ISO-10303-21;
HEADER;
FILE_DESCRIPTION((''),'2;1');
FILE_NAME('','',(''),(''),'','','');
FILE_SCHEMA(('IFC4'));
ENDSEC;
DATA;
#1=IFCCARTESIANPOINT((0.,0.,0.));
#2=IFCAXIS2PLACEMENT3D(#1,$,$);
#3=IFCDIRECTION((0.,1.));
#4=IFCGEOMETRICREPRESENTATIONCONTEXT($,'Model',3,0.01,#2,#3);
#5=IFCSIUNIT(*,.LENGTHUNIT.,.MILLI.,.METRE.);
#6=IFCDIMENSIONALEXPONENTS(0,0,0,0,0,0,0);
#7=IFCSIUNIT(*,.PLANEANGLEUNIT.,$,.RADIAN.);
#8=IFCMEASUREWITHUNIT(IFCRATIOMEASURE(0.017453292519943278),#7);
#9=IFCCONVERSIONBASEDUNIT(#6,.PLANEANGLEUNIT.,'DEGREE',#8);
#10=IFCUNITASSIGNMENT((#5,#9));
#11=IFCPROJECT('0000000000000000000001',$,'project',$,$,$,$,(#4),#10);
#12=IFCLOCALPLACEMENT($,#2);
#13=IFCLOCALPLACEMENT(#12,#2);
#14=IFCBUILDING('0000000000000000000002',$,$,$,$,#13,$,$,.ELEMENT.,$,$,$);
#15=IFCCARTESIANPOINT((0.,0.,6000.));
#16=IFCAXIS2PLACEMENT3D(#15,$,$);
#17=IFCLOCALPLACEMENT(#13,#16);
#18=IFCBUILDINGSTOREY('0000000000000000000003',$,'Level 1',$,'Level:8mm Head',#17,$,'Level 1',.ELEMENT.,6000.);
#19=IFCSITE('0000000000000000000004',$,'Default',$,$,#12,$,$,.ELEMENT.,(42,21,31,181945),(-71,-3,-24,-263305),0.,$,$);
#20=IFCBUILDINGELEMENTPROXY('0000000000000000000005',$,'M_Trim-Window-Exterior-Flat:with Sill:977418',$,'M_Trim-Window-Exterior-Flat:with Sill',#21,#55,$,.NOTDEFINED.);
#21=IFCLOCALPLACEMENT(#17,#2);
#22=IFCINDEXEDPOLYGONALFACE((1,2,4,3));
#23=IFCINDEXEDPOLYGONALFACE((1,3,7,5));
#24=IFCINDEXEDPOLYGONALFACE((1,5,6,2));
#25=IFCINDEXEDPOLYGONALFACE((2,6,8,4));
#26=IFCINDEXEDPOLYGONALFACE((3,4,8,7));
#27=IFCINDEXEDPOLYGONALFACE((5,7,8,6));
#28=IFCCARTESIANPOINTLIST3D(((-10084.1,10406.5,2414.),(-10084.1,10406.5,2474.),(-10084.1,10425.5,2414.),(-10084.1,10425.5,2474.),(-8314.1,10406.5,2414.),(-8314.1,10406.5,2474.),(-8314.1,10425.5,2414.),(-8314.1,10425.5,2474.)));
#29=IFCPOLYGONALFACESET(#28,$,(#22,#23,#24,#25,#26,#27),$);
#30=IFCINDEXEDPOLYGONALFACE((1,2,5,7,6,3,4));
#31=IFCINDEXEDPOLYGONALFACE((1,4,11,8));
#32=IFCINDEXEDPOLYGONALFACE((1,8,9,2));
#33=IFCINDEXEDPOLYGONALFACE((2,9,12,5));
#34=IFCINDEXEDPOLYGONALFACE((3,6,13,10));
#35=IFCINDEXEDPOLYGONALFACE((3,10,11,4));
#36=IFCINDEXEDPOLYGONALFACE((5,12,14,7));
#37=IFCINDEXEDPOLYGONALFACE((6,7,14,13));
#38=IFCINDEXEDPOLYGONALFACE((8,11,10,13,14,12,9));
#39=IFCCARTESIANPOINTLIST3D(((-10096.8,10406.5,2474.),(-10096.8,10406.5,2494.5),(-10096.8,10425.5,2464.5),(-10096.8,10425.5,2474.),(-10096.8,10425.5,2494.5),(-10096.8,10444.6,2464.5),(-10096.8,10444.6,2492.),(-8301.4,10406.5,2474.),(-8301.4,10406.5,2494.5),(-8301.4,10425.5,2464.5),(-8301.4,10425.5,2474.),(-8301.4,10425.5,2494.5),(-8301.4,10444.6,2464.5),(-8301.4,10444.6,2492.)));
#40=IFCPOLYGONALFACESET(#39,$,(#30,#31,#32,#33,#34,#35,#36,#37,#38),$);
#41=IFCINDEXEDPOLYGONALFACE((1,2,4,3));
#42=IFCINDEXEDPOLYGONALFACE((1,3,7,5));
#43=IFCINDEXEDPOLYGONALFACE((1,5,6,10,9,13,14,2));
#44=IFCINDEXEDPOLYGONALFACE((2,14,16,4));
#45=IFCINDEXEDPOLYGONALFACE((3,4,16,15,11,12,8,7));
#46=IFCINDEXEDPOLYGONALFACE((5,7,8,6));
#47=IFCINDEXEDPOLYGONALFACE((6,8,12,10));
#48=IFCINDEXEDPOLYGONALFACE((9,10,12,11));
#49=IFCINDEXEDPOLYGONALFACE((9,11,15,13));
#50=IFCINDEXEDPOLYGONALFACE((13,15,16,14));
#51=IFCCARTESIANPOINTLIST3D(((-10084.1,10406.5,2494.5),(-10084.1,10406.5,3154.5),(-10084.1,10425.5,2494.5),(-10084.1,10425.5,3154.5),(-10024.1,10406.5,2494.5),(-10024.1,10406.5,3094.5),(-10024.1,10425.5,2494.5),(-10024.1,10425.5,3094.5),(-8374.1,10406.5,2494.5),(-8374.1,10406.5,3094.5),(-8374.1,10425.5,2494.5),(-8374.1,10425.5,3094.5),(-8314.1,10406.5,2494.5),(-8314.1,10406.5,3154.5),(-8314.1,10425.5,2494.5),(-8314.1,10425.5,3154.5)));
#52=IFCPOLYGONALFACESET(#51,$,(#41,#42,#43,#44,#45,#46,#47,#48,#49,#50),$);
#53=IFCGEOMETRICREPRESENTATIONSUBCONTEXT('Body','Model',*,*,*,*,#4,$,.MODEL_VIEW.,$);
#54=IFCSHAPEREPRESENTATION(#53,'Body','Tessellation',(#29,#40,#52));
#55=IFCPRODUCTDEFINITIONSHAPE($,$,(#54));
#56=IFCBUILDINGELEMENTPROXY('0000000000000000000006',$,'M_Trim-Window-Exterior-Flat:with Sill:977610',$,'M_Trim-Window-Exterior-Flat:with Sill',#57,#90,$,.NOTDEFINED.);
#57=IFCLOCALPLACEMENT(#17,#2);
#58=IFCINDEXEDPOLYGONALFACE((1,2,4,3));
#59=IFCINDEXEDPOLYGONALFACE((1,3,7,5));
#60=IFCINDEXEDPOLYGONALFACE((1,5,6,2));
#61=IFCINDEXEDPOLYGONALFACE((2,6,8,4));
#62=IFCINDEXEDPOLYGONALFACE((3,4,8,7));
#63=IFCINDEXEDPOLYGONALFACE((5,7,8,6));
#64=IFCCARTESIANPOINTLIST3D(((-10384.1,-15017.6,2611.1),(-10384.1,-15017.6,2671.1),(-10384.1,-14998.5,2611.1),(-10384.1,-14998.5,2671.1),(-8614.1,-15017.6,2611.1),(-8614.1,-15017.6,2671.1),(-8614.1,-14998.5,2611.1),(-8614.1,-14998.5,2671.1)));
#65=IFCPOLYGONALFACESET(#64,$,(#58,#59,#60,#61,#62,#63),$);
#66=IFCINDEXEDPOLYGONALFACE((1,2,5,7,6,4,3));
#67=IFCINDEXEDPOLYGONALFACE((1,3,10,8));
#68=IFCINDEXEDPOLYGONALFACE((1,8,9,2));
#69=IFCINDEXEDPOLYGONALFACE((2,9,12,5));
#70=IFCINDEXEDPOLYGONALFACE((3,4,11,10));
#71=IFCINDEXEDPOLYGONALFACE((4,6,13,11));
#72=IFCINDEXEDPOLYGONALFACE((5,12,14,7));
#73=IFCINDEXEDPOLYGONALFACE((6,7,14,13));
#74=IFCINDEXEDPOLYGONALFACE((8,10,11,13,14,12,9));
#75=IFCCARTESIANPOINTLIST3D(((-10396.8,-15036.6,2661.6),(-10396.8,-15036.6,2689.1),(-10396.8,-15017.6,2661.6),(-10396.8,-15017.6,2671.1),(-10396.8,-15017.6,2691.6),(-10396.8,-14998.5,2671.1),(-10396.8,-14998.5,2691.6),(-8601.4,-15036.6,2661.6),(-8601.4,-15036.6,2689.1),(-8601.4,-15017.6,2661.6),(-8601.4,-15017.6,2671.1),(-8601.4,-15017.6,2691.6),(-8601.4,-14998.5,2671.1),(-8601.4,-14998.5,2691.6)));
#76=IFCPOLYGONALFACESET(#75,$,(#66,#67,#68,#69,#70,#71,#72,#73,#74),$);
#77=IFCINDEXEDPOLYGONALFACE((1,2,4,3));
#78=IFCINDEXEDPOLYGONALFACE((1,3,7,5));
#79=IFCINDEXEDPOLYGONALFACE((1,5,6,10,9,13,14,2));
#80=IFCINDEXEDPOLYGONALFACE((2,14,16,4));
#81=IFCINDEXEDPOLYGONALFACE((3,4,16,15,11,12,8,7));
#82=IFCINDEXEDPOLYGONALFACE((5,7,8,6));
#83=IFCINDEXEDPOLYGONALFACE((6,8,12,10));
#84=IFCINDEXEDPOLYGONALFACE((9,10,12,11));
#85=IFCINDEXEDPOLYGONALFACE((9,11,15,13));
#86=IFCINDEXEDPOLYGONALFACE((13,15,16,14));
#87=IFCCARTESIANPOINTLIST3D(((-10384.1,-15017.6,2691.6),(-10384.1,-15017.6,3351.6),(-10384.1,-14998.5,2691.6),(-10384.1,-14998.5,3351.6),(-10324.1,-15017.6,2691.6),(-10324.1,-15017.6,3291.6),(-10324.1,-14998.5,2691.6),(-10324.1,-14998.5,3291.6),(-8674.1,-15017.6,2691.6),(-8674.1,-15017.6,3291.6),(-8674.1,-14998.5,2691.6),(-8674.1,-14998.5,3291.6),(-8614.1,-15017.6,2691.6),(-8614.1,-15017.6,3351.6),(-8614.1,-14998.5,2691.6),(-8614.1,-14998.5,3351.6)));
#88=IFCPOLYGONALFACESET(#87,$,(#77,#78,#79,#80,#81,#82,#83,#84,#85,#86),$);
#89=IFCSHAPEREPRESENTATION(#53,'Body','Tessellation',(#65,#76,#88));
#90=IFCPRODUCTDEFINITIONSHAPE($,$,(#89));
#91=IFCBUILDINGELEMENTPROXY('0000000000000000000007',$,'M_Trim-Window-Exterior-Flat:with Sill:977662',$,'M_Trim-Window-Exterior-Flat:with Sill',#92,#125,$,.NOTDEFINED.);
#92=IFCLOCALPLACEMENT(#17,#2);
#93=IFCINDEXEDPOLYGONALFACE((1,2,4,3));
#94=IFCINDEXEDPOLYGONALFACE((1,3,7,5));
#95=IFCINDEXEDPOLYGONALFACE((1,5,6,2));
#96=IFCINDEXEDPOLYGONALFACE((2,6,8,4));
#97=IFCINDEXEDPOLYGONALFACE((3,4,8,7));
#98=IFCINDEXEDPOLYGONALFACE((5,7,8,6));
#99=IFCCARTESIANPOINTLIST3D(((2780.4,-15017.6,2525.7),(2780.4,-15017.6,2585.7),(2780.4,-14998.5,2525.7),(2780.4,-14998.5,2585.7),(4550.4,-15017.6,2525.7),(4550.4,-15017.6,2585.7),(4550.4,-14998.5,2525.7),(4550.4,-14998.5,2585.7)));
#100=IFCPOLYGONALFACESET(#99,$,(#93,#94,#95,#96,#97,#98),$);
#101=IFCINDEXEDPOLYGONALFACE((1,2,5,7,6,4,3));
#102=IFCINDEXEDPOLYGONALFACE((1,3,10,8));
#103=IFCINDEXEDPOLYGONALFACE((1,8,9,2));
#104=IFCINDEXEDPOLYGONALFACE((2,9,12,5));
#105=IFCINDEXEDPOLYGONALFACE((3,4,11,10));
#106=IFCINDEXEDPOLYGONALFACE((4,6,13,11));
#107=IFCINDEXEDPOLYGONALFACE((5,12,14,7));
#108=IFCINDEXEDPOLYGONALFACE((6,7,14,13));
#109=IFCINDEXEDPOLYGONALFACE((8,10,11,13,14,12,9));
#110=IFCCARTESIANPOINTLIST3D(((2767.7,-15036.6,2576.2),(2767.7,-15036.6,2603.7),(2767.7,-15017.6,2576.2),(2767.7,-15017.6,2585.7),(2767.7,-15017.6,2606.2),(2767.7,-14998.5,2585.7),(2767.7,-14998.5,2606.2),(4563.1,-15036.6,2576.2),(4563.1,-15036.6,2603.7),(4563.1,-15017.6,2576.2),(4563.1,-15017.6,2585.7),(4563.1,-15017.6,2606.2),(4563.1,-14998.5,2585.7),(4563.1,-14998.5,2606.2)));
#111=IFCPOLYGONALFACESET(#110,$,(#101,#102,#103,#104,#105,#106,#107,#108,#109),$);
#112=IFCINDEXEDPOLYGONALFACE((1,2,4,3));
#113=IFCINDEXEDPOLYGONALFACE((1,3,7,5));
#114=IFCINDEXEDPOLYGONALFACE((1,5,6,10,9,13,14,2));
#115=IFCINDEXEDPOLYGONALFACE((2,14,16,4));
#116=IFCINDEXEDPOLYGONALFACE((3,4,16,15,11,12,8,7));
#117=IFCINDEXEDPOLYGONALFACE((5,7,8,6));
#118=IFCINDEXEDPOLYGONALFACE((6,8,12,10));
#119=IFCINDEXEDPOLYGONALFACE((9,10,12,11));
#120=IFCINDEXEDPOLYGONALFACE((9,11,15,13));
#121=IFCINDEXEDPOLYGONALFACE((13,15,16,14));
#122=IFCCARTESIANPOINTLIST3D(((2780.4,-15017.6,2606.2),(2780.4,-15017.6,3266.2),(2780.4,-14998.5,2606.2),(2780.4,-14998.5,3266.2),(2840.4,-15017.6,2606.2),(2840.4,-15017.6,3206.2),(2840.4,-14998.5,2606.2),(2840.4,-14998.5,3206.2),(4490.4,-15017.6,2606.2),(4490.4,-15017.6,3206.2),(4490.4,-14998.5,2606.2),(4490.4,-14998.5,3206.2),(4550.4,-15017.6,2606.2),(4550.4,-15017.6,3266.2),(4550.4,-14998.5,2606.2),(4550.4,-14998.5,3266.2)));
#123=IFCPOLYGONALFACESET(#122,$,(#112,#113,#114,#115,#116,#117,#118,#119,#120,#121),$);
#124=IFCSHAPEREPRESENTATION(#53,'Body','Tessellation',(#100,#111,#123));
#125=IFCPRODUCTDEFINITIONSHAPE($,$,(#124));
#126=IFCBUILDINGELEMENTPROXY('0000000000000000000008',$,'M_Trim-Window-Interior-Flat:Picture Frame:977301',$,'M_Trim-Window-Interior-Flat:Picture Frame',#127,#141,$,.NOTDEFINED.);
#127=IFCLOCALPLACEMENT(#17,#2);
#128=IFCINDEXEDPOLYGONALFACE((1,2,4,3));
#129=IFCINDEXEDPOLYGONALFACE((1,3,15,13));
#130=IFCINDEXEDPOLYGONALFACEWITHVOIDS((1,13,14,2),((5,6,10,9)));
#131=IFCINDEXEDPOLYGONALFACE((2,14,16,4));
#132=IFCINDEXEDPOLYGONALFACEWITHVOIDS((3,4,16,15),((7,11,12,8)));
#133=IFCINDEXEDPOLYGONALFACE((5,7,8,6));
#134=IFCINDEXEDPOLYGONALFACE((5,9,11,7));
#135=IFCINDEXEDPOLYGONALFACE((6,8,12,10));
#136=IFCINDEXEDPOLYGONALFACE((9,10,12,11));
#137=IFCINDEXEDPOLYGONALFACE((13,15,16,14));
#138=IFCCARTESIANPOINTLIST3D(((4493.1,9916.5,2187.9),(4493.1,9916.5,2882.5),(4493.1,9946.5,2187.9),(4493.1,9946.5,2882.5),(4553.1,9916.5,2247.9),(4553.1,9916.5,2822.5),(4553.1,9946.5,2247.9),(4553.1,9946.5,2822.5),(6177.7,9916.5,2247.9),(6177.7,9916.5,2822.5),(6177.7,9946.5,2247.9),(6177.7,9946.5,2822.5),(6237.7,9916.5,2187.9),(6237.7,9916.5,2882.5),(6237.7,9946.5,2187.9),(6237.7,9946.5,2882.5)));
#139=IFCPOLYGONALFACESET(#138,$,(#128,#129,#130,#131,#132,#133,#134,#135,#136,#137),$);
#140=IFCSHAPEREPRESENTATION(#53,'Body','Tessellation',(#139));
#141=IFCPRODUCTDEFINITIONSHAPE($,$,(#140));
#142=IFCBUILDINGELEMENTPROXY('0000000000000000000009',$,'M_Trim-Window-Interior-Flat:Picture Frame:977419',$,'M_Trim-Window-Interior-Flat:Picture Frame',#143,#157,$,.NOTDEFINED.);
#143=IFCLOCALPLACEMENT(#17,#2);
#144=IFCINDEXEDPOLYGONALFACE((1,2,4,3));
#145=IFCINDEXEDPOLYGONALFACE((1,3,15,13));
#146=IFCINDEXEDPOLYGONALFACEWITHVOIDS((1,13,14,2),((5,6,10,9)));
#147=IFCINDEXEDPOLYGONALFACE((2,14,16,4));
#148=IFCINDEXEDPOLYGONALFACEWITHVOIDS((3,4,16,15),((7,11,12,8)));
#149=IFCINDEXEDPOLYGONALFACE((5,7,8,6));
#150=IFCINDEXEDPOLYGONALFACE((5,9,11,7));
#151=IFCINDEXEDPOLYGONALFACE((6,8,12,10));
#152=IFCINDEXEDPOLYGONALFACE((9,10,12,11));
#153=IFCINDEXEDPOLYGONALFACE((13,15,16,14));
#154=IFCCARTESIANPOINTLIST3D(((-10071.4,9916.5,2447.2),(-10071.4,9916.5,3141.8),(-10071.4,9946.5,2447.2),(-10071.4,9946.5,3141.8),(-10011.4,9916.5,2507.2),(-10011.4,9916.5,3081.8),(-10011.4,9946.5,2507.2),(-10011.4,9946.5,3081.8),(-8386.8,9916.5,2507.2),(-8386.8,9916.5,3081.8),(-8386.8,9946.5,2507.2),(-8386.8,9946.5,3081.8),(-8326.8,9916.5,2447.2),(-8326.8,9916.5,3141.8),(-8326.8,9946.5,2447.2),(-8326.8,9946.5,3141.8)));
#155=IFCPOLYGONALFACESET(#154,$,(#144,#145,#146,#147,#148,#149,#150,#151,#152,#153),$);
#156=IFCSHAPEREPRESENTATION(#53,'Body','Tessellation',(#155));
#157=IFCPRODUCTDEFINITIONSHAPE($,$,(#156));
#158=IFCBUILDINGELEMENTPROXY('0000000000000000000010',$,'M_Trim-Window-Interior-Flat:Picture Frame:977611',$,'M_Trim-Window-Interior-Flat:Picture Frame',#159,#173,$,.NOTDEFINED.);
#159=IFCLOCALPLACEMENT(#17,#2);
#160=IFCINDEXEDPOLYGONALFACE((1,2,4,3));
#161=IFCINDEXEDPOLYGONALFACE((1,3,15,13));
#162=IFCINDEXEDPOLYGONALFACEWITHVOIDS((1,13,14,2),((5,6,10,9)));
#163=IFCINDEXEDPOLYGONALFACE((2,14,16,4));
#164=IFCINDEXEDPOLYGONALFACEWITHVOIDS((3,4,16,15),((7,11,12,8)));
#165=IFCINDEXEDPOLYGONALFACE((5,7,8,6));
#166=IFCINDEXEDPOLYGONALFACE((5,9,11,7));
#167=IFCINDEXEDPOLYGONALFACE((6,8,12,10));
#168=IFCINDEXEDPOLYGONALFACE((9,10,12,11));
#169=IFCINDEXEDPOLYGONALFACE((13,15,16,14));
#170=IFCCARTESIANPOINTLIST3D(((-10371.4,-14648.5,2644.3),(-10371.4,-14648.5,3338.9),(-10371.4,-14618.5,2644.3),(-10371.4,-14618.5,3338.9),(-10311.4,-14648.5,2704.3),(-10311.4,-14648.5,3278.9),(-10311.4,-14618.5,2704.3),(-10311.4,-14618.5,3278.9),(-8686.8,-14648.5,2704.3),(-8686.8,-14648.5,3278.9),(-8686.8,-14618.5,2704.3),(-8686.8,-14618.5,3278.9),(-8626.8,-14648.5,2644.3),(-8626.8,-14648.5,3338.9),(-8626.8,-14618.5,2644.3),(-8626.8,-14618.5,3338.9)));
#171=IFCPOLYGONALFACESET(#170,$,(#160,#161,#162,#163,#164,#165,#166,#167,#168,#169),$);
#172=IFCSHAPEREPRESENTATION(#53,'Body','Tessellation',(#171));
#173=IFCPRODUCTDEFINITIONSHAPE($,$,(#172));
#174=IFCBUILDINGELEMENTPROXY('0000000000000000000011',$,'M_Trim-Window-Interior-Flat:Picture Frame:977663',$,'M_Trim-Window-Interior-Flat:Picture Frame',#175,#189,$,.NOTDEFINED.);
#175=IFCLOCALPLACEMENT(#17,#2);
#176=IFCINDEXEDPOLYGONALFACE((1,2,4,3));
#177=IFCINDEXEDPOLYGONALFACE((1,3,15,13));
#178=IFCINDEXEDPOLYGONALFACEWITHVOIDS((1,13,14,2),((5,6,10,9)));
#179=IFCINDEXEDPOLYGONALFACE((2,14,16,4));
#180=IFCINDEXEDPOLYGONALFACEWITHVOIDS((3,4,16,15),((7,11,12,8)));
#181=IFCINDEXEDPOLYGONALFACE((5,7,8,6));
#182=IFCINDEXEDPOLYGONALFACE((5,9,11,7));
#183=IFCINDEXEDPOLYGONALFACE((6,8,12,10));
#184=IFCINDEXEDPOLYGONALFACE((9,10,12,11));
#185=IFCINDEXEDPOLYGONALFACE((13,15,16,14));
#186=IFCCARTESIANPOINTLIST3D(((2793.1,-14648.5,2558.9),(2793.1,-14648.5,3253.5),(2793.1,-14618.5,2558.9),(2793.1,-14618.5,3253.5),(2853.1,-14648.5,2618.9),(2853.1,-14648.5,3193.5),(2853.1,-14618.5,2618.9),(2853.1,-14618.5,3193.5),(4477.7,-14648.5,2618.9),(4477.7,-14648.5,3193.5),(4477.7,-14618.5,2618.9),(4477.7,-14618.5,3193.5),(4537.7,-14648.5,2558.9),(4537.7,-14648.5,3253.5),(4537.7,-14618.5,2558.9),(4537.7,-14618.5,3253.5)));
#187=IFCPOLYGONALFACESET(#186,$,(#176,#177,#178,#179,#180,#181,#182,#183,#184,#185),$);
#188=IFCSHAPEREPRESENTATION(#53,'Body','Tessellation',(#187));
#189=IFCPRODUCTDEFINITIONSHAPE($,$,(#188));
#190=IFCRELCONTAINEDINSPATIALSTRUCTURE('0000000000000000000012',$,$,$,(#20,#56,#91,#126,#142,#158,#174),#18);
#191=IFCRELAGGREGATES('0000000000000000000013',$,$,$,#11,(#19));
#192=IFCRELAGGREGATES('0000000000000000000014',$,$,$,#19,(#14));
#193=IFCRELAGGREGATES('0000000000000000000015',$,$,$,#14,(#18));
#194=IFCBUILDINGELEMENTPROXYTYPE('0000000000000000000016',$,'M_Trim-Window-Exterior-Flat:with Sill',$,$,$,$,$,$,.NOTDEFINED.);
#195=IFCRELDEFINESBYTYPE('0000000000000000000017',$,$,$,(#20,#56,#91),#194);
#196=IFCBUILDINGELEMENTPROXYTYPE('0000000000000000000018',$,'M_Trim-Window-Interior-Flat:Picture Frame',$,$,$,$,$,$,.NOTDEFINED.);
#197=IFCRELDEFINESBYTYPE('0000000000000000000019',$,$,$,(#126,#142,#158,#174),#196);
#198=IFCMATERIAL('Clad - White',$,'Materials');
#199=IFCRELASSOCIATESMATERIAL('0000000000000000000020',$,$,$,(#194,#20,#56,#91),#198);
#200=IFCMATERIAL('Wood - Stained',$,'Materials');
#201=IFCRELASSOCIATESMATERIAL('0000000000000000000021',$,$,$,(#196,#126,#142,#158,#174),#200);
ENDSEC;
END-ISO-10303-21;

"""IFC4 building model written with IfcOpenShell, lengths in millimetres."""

from ifc_helpers import new_model, entity, si_unit, converted_unit, direction, frame, frame_2d, origin, place, context, subcontext, project, spatial, polyline, rectangle, outline, extrude, source, transform, mapped, material, type_object, type_shapes, element, save


model = new_model("IFC4")

# Units and contexts
model_context = context("Model", 3, precision=0.01, world=origin(), true_north=direction((0.0, 1.0)))
body_context = subcontext(model_context, "Body", "Model", "MODEL_VIEW")
ifc_project = project(units=[si_unit("LENGTHUNIT", "METRE", prefix="MILLI"), converted_unit("PLANEANGLEUNIT", "DEGREE", entity("IfcRatioMeasure", 0.017453292519943278), si_unit("PLANEANGLEUNIT", "RADIAN"), dimensions=[0, 0, 0, 0, 0, 0, 0])], contexts=[model_context])

# Site, building, storey
site_placement = place(None, origin())
site = spatial("IfcSite", under=ifc_project, at=site_placement, Name="Default", CompositionType="ELEMENT", RefLatitude=(42, 21, 31, 181945), RefLongitude=(-71, -3, -24, -263305), RefElevation=0.0)
building_placement = place(site_placement, origin())
building = spatial("IfcBuilding", under=site, at=building_placement, CompositionType="ELEMENT")
storey_placement = place(building_placement, frame((0.0, 0.0, 6000.0)))
storey = spatial("IfcBuildingStorey", under=building, at=storey_placement, Name="Level 1", ObjectType="Level:8mm Head", LongName="Level 1", CompositionType="ELEMENT", Elevation=6000.0)

# Building element proxies
ifc_material_1 = material(Name="Clad - White", Category="Materials")
ifc_material_2 = material(Name="Wood - Stained", Category="Materials")
building_element_proxy_type_1 = type_object("IfcBuildingElementProxyType", Name="M_Trim-Window-Exterior-Flat:with Sill", PredefinedType="NOTDEFINED", material=ifc_material_1)
shared_shape_1 = source(origin(), body_context, "Body", "SweptSolid", [
    extrude(rectangle(XDim=1770.0, YDim=60.0, at=frame_2d((0.0, 0.0), x_axis=(1.0, 0.0))), frame((0.0, -650.4, 0.0), z_axis=(0.0, 0.0, 1.0), x_axis=(-1.0, 0.0, 0.0)), (0.0, 0.0, 1.0), 19.0),
    extrude(outline(polyline([(-19.0, -15.2), (0.0, -15.2), (0.0, -5.7), (19.0, -5.7), (19.0, 14.8), (0.0, 14.8), (-19.0, 12.3), (-19.0, -15.2)])), frame((-897.7, -614.8, 19.0), z_axis=(1.0, 0.0, 0.0), x_axis=(0.0, 0.0, -1.0)), (0.0, 0.0, 1.0), 1795.4),
    extrude(outline(polyline([(-345.0, -885.0), (315.0, -885.0), (315.0, -825.0), (-285.0, -825.0), (-285.0, 825.0), (315.0, 825.0), (315.0, 885.0), (-345.0, 885.0), (-345.0, -885.0)])), frame((0.0, -285.0, 0.0), z_axis=(0.0, 0.0, 1.0), x_axis=(0.0, -1.0, 0.0)), (0.0, 0.0, 1.0), 19.0),
])
type_shapes(building_element_proxy_type_1, [shared_shape_1])
for number, where, z_axis, x_axis, name in (
    (1, (-9199.1, 10406.5, 3094.5), (0.0, 1.0, 0.0), (-1.0, 0.0, 0.0), "M_Trim-Window-Exterior-Flat:with Sill:977418"),
    (2, (-9499.1, -14998.5, 3291.6), (0.0, -1.0, 0.0), (1.0, 0.0, 0.0), "M_Trim-Window-Exterior-Flat:with Sill:977610"),
    (3, (3665.4, -14998.5, 3206.2), (0.0, -1.0, 0.0), (1.0, 0.0, 0.0), "M_Trim-Window-Exterior-Flat:with Sill:977662"),
):
    element("IfcBuildingElementProxy", number, at=place(storey_placement, frame(where, z_axis=z_axis, x_axis=x_axis)), inside=storey, type_object=building_element_proxy_type_1, material=ifc_material_1, Name=name, ObjectType="M_Trim-Window-Exterior-Flat:with Sill", PredefinedType="NOTDEFINED", context=body_context, shape_type="MappedRepresentation", body=[
        mapped(shared_shape_1, transform((0.0, 0.0, 0.0), scale=1.0)),
    ])
building_element_proxy_type_2 = type_object("IfcBuildingElementProxyType", Name="M_Trim-Window-Interior-Flat:Picture Frame", PredefinedType="NOTDEFINED", material=ifc_material_2)
shared_shape_2 = source(origin(), body_context, "Body", "SweptSolid", [
    extrude(outline(polyline([(-872.3, -347.3), (872.3, -347.3), (872.3, 347.3), (-872.3, 347.3), (-872.3, -347.3)]), holes=[polyline([(-812.3, -287.3), (-812.3, 287.3), (812.3, 287.3), (812.3, -287.3), (-812.3, -287.3)])]), frame((0.0, -300.0, 0.0), z_axis=(0.0, 0.0, 1.0), x_axis=(-1.0, 0.0, 0.0)), (0.0, 0.0, 1.0), 30.0),
])
type_shapes(building_element_proxy_type_2, [shared_shape_2])
for number, where, z_axis, x_axis, name in (
    (4, (5365.4, 9946.5, 2835.2), (0.0, -1.0, 0.0), (1.0, 0.0, 0.0), "M_Trim-Window-Interior-Flat:Picture Frame:977301"),
    (5, (-9199.1, 9946.5, 3094.5), (0.0, -1.0, 0.0), (1.0, 0.0, 0.0), "M_Trim-Window-Interior-Flat:Picture Frame:977419"),
    (6, (-9499.1, -14648.5, 3291.6), (0.0, 1.0, 0.0), (-1.0, 0.0, 0.0), "M_Trim-Window-Interior-Flat:Picture Frame:977611"),
    (7, (3665.4, -14648.5, 3206.2), (0.0, 1.0, 0.0), (-1.0, 0.0, 0.0), "M_Trim-Window-Interior-Flat:Picture Frame:977663"),
):
    element("IfcBuildingElementProxy", number, at=place(storey_placement, frame(where, z_axis=z_axis, x_axis=x_axis)), inside=storey, type_object=building_element_proxy_type_2, material=ifc_material_2, Name=name, ObjectType="M_Trim-Window-Interior-Flat:Picture Frame", PredefinedType="NOTDEFINED", context=body_context, shape_type="MappedRepresentation", body=[
        mapped(shared_shape_2, transform((0.0, 0.0, 0.0), scale=1.0)),
    ])

save(model, "model.ifc")
